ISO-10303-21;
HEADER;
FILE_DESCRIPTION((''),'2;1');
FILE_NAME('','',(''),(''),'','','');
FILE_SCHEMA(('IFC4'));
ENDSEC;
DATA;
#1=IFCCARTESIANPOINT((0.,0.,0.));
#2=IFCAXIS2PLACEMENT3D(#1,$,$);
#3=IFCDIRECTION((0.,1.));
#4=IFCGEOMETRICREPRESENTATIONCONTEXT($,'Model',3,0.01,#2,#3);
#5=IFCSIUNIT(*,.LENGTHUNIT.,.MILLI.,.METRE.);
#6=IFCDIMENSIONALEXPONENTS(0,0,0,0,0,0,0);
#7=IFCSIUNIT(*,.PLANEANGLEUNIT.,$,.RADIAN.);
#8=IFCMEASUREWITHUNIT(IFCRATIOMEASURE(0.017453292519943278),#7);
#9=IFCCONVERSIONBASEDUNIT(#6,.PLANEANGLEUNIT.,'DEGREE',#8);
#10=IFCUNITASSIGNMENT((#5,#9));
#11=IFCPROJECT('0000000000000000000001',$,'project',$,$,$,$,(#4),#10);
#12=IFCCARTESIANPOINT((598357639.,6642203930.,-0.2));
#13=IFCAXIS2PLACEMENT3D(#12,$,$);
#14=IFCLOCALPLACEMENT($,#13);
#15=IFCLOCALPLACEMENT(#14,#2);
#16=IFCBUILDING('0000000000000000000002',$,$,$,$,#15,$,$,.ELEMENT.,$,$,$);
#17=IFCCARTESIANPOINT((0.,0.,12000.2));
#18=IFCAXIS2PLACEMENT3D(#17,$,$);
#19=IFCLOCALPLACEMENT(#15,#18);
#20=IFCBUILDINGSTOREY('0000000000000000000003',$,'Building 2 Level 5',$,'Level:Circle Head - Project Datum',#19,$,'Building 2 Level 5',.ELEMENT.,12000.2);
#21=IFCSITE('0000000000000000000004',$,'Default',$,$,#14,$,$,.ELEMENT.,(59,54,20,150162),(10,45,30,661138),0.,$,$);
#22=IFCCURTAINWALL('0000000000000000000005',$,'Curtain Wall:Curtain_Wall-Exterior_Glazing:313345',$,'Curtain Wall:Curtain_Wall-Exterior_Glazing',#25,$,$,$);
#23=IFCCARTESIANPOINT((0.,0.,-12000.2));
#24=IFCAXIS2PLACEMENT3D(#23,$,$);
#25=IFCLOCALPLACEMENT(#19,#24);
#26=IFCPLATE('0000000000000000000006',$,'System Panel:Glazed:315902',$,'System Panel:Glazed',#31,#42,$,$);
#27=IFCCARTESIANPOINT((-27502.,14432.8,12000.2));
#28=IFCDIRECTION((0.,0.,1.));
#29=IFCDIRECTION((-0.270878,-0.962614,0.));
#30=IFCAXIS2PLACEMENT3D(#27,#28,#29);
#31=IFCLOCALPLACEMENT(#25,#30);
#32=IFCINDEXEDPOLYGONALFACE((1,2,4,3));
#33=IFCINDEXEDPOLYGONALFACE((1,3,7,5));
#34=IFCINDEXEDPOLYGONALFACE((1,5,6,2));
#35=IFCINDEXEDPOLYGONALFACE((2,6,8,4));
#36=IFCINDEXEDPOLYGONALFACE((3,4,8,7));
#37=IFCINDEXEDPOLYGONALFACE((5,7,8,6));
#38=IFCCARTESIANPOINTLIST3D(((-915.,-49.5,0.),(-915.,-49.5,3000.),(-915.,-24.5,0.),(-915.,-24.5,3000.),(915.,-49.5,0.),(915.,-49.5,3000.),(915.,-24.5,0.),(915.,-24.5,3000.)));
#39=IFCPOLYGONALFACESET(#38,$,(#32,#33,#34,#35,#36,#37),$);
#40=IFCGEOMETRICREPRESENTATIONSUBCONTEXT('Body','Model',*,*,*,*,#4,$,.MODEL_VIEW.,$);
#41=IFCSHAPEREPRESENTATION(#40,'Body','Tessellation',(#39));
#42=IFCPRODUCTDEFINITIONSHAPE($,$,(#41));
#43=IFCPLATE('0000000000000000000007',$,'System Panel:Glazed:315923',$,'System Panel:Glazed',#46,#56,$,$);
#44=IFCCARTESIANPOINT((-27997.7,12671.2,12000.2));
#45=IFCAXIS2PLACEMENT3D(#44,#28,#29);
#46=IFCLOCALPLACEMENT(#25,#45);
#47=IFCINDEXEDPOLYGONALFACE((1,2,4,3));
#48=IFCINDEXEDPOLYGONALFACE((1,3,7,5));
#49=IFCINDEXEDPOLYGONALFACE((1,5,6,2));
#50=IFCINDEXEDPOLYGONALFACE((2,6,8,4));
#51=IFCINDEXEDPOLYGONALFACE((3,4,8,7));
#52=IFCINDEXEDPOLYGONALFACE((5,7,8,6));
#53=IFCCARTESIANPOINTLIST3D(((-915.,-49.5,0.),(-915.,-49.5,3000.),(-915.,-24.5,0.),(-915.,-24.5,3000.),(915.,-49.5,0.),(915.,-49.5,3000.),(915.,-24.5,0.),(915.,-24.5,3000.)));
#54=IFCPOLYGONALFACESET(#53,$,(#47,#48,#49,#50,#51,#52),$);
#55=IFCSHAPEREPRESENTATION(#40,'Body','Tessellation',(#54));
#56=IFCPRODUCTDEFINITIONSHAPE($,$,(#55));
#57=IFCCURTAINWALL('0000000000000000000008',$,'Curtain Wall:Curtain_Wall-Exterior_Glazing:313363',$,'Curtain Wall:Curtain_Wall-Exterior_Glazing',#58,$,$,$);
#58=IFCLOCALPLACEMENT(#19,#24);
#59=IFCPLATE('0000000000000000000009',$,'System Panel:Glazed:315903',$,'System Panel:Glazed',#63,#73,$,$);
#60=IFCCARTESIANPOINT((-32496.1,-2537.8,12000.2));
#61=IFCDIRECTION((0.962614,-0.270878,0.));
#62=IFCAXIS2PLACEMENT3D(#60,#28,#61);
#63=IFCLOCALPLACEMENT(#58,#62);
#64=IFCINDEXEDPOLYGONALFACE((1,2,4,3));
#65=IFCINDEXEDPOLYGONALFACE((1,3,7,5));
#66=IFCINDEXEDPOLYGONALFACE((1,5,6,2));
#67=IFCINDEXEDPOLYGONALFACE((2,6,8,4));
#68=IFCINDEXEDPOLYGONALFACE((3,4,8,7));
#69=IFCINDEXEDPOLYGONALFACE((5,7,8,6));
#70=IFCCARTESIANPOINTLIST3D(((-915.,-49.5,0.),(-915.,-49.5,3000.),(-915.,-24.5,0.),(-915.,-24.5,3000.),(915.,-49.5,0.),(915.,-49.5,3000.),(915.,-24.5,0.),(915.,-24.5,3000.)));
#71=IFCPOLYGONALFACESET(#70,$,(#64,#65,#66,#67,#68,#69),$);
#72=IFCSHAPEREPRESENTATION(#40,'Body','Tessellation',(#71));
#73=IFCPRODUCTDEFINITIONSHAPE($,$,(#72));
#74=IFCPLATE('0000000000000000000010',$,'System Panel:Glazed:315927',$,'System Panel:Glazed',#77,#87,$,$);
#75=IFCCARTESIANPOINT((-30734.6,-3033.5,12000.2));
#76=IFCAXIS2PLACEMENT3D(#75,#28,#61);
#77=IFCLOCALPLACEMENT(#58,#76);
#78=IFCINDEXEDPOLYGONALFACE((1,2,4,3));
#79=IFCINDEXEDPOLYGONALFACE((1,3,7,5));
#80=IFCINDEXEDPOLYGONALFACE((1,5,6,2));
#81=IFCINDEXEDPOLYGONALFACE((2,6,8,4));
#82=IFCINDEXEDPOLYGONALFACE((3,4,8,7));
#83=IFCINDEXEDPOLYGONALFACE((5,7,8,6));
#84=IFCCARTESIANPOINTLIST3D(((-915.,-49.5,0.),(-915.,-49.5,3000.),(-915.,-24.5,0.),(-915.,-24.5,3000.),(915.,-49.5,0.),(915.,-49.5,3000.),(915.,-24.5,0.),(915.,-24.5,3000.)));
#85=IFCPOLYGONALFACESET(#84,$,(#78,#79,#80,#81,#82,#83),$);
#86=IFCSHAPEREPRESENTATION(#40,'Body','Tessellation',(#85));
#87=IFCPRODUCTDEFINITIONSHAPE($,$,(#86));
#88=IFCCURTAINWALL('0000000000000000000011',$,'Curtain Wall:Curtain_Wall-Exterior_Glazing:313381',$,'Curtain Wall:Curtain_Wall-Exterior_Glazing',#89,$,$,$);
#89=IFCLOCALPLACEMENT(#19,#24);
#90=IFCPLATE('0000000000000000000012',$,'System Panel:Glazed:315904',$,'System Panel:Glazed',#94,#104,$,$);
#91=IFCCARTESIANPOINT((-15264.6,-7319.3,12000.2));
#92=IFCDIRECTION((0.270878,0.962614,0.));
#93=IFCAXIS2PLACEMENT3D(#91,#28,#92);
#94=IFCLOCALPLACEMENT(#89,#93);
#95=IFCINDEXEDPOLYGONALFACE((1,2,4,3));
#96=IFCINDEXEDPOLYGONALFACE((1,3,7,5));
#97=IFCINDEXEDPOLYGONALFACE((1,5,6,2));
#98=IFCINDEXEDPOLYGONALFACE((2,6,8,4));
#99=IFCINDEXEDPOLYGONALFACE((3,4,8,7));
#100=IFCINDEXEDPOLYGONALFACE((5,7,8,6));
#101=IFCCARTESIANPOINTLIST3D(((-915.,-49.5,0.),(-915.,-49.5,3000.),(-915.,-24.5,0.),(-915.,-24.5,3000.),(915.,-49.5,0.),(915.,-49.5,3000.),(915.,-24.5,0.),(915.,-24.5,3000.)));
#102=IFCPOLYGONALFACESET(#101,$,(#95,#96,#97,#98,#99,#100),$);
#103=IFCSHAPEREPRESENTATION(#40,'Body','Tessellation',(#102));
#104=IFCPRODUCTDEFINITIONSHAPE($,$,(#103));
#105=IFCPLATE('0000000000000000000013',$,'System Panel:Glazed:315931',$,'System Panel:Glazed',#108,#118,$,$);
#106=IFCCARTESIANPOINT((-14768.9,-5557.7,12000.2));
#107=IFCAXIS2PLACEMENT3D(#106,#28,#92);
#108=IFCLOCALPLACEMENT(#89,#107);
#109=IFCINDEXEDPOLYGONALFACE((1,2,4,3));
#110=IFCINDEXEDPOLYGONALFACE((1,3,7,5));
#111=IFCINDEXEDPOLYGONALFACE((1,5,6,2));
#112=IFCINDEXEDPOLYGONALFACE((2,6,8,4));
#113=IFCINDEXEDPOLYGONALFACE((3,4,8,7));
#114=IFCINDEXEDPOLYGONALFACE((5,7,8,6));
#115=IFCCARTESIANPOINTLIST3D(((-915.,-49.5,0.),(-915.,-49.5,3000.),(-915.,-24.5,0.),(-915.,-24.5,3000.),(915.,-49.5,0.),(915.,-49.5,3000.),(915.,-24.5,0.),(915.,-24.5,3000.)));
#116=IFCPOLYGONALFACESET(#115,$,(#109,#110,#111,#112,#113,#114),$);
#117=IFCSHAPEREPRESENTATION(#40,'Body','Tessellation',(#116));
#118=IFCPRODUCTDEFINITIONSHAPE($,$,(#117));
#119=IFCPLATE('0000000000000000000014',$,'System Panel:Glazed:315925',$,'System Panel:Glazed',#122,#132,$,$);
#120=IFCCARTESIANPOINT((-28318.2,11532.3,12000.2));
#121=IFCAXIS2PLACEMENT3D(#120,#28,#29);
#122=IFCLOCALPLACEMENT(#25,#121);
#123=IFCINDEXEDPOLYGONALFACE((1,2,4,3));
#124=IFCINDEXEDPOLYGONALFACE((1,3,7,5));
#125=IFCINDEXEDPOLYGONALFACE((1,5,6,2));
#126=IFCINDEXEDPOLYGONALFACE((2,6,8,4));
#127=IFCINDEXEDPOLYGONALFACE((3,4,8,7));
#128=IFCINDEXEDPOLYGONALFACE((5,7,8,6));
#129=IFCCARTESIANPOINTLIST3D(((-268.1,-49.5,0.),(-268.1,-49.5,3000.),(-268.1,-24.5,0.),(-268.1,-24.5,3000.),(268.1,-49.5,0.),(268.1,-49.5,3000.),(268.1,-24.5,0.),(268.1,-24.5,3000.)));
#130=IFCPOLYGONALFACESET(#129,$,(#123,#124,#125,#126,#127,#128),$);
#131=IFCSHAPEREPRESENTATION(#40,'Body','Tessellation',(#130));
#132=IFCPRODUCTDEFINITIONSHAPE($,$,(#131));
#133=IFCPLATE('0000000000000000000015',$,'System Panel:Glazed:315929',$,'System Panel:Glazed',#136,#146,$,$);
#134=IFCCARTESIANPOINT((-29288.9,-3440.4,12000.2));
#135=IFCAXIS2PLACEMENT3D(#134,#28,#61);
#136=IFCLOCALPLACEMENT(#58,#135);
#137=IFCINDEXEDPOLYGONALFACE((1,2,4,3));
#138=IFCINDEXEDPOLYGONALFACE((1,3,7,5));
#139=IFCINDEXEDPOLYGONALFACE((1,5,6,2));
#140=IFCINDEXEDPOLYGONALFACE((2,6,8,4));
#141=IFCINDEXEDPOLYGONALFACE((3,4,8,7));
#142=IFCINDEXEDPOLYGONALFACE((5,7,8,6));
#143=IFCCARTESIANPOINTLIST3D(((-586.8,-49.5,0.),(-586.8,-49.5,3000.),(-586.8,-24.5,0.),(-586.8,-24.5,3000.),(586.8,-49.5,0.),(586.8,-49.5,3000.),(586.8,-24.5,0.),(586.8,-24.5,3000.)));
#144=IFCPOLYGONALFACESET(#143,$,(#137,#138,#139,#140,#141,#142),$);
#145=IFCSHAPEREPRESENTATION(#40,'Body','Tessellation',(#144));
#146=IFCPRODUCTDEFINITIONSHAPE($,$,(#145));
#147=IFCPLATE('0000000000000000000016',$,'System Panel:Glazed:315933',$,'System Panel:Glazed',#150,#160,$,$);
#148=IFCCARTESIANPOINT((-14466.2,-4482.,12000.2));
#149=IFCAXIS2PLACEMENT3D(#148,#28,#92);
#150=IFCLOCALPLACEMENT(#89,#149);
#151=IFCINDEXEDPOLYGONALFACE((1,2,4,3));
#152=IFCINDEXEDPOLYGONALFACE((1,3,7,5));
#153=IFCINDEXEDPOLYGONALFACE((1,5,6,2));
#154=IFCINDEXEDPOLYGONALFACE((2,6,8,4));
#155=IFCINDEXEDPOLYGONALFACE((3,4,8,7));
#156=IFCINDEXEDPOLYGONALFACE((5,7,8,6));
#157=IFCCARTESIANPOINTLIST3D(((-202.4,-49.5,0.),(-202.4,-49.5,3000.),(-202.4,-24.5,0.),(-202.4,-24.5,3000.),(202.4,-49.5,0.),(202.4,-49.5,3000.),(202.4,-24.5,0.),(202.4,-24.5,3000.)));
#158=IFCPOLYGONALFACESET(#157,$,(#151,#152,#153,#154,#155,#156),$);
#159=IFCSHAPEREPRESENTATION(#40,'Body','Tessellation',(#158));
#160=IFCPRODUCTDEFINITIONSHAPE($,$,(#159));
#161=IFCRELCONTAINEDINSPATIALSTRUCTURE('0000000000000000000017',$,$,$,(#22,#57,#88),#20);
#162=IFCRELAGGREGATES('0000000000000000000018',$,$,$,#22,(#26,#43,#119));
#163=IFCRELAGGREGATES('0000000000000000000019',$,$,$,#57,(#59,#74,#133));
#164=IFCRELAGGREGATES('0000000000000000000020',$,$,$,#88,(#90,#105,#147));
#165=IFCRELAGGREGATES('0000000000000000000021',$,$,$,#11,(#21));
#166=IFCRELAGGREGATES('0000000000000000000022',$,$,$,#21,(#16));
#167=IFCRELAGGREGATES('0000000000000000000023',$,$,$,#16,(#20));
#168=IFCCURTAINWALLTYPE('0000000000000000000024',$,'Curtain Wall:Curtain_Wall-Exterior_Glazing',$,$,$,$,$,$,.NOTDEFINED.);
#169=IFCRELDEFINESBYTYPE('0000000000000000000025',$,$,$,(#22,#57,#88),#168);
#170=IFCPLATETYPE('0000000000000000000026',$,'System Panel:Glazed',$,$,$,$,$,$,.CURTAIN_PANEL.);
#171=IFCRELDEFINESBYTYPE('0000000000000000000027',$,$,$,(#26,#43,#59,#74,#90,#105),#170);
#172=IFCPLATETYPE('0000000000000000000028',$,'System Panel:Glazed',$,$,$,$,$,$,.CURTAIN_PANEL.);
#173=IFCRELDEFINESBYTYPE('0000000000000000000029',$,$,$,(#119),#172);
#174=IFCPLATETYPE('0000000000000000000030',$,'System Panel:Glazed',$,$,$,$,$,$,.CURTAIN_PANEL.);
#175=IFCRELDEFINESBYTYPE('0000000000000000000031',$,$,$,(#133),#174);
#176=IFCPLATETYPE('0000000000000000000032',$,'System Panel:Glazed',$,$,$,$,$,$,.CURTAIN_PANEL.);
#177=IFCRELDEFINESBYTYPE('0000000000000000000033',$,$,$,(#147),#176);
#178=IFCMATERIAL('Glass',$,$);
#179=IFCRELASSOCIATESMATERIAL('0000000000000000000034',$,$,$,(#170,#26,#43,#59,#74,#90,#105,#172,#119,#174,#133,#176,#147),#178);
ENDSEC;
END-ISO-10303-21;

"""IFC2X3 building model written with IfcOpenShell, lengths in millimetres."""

from ifc_helpers import new_model, entity, si_unit, converted_unit, direction, frame, frame_2d, origin, place, context, subcontext, project, spatial, rectangle, extrude, source, transform, mapped, material, type_object, type_shapes, element, aggregate, save


model = new_model("IFC2X3")

# Units and contexts
model_context = context("Model", 3, precision=0.01, world=origin(), true_north=direction((0.0, 1.0)))
body_context = subcontext(model_context, "Body", "Model", "MODEL_VIEW")
ifc_project = project(units=[si_unit("LENGTHUNIT", "METRE", prefix="MILLI"), converted_unit("PLANEANGLEUNIT", "DEGREE", entity("IfcRatioMeasure", 0.017453292519943278), si_unit("PLANEANGLEUNIT", "RADIAN"), dimensions=[0, 0, 0, 0, 0, 0, 0])], contexts=[model_context])

# Site, building, storey
site_placement = place(None, frame((598357639.0, 6642203930.0, -0.2)))
site = spatial("IfcSite", under=ifc_project, at=site_placement, Name="Default", CompositionType="ELEMENT", RefLatitude=(59, 54, 20, 150162), RefLongitude=(10, 45, 30, 661138), RefElevation=0.0)
building_placement = place(site_placement, origin())
building = spatial("IfcBuilding", under=site, at=building_placement, CompositionType="ELEMENT")
storey_placement = place(building_placement, frame((0.0, 0.0, 12000.2)))
storey = spatial("IfcBuildingStorey", under=building, at=storey_placement, Name="Building 2 Level 5", ObjectType="Level:Circle Head - Project Datum", LongName="Building 2 Level 5", CompositionType="ELEMENT", Elevation=12000.2)

# Curtain walls, plates
curtain_wall_type = type_object("IfcCurtainWallType", Name="Curtain Wall:Curtain_Wall-Exterior_Glazing", PredefinedType="NOTDEFINED")
curtain_wall_1_placement = place(storey_placement, frame((0.0, 0.0, -12000.2)))
curtain_wall_1 = element("IfcCurtainWall", 1, at=curtain_wall_1_placement, inside=storey, type_object=curtain_wall_type, Name="Curtain Wall:Curtain_Wall-Exterior_Glazing:313345", ObjectType="Curtain Wall:Curtain_Wall-Exterior_Glazing")
ifc_material_1 = material(Name="Glass")
plate_type_1 = type_object("IfcPlateType", Name="System Panel:Glazed", PredefinedType="CURTAIN_PANEL", material=ifc_material_1)
shared_shape_1 = source(origin(), body_context, "Body", "SweptSolid", [
    extrude(rectangle(XDim=25.0, YDim=1830.0, at=frame_2d((0.0, 0.0), x_axis=(1.0, 0.0))), frame((0.0, -37.0, 0.0), z_axis=(0.0, 0.0, 1.0), x_axis=(0.0, 1.0, 0.0)), (0.0, 0.0, 1.0), 3000.0),
])
type_shapes(plate_type_1, [shared_shape_1])
plate_1_placement = place(curtain_wall_1_placement, frame((-27502.0, 14432.8, 12000.2), z_axis=(0.0, 0.0, 1.0), x_axis=(-0.270878, -0.962614, 0.0)))
plate_1 = element("IfcPlate", 2, at=plate_1_placement, type_object=plate_type_1, material=ifc_material_1, Name="System Panel:Glazed:315902", ObjectType="System Panel:Glazed", context=body_context, shape_type="MappedRepresentation", body=[
    mapped(shared_shape_1, transform((0.0, 0.0, 0.0), scale=1.0)),
])
plate_2_placement = place(curtain_wall_1_placement, frame((-27997.7, 12671.2, 12000.2), z_axis=(0.0, 0.0, 1.0), x_axis=(-0.270878, -0.962614, 0.0)))
plate_2 = element("IfcPlate", 3, at=plate_2_placement, type_object=plate_type_1, material=ifc_material_1, Name="System Panel:Glazed:315923", ObjectType="System Panel:Glazed", context=body_context, shape_type="MappedRepresentation", body=[
    mapped(shared_shape_1, transform((0.0, 0.0, 0.0), scale=1.0)),
])
curtain_wall_2_placement = place(storey_placement, frame((0.0, 0.0, -12000.2)))
curtain_wall_2 = element("IfcCurtainWall", 4, at=curtain_wall_2_placement, inside=storey, type_object=curtain_wall_type, Name="Curtain Wall:Curtain_Wall-Exterior_Glazing:313363", ObjectType="Curtain Wall:Curtain_Wall-Exterior_Glazing")
plate_3_placement = place(curtain_wall_2_placement, frame((-32496.1, -2537.8, 12000.2), z_axis=(0.0, 0.0, 1.0), x_axis=(0.962614, -0.270878, 0.0)))
plate_3 = element("IfcPlate", 5, at=plate_3_placement, type_object=plate_type_1, material=ifc_material_1, Name="System Panel:Glazed:315903", ObjectType="System Panel:Glazed", context=body_context, shape_type="MappedRepresentation", body=[
    mapped(shared_shape_1, transform((0.0, 0.0, 0.0), scale=1.0)),
])
plate_4_placement = place(curtain_wall_2_placement, frame((-30734.6, -3033.5, 12000.2), z_axis=(0.0, 0.0, 1.0), x_axis=(0.962614, -0.270878, 0.0)))
plate_4 = element("IfcPlate", 6, at=plate_4_placement, type_object=plate_type_1, material=ifc_material_1, Name="System Panel:Glazed:315927", ObjectType="System Panel:Glazed", context=body_context, shape_type="MappedRepresentation", body=[
    mapped(shared_shape_1, transform((0.0, 0.0, 0.0), scale=1.0)),
])
curtain_wall_3_placement = place(storey_placement, frame((0.0, 0.0, -12000.2)))
curtain_wall_3 = element("IfcCurtainWall", 7, at=curtain_wall_3_placement, inside=storey, type_object=curtain_wall_type, Name="Curtain Wall:Curtain_Wall-Exterior_Glazing:313381", ObjectType="Curtain Wall:Curtain_Wall-Exterior_Glazing")
plate_5_placement = place(curtain_wall_3_placement, frame((-15264.6, -7319.3, 12000.2), z_axis=(0.0, 0.0, 1.0), x_axis=(0.270878, 0.962614, 0.0)))
plate_5 = element("IfcPlate", 8, at=plate_5_placement, type_object=plate_type_1, material=ifc_material_1, Name="System Panel:Glazed:315904", ObjectType="System Panel:Glazed", context=body_context, shape_type="MappedRepresentation", body=[
    mapped(shared_shape_1, transform((0.0, 0.0, 0.0), scale=1.0)),
])
plate_6_placement = place(curtain_wall_3_placement, frame((-14768.9, -5557.7, 12000.2), z_axis=(0.0, 0.0, 1.0), x_axis=(0.270878, 0.962614, 0.0)))
plate_6 = element("IfcPlate", 9, at=plate_6_placement, type_object=plate_type_1, material=ifc_material_1, Name="System Panel:Glazed:315931", ObjectType="System Panel:Glazed", context=body_context, shape_type="MappedRepresentation", body=[
    mapped(shared_shape_1, transform((0.0, 0.0, 0.0), scale=1.0)),
])

# Plates
plate_type_2 = type_object("IfcPlateType", Name="System Panel:Glazed", PredefinedType="CURTAIN_PANEL", material=ifc_material_1)
shared_shape_2 = source(origin(), body_context, "Body", "SweptSolid", [
    extrude(rectangle(XDim=25.0, YDim=536.2, at=frame_2d((0.0, 0.0), x_axis=(1.0, 0.0))), frame((0.0, -37.0, 0.0), z_axis=(0.0, 0.0, 1.0), x_axis=(0.0, 1.0, 0.0)), (0.0, 0.0, 1.0), 3000.0),
])
type_shapes(plate_type_2, [shared_shape_2])
plate_7_placement = place(curtain_wall_1_placement, frame((-28318.2, 11532.3, 12000.2), z_axis=(0.0, 0.0, 1.0), x_axis=(-0.270878, -0.962614, 0.0)))
plate_7 = element("IfcPlate", 10, at=plate_7_placement, type_object=plate_type_2, material=ifc_material_1, Name="System Panel:Glazed:315925", ObjectType="System Panel:Glazed", context=body_context, shape_type="MappedRepresentation", body=[
    mapped(shared_shape_2, transform((0.0, 0.0, 0.0), scale=1.0)),
])
aggregate(curtain_wall_1, [plate_1, plate_2, plate_7])
plate_type_3 = type_object("IfcPlateType", Name="System Panel:Glazed", PredefinedType="CURTAIN_PANEL", material=ifc_material_1)
shared_shape_3 = source(origin(), body_context, "Body", "SweptSolid", [
    extrude(rectangle(XDim=25.0, YDim=1173.6, at=frame_2d((0.0, 0.0), x_axis=(1.0, 0.0))), frame((0.0, -37.0, 0.0), z_axis=(0.0, 0.0, 1.0), x_axis=(0.0, 1.0, 0.0)), (0.0, 0.0, 1.0), 3000.0),
])
type_shapes(plate_type_3, [shared_shape_3])
plate_8_placement = place(curtain_wall_2_placement, frame((-29288.9, -3440.4, 12000.2), z_axis=(0.0, 0.0, 1.0), x_axis=(0.962614, -0.270878, 0.0)))
plate_8 = element("IfcPlate", 11, at=plate_8_placement, type_object=plate_type_3, material=ifc_material_1, Name="System Panel:Glazed:315929", ObjectType="System Panel:Glazed", context=body_context, shape_type="MappedRepresentation", body=[
    mapped(shared_shape_3, transform((0.0, 0.0, 0.0), scale=1.0)),
])
aggregate(curtain_wall_2, [plate_3, plate_4, plate_8])
plate_type_4 = type_object("IfcPlateType", Name="System Panel:Glazed", PredefinedType="CURTAIN_PANEL", material=ifc_material_1)
shared_shape_4 = source(origin(), body_context, "Body", "SweptSolid", [
    extrude(rectangle(XDim=25.0, YDim=404.8, at=frame_2d((0.0, 0.0), x_axis=(1.0, 0.0))), frame((0.0, -37.0, 0.0), z_axis=(0.0, 0.0, 1.0), x_axis=(0.0, 1.0, 0.0)), (0.0, 0.0, 1.0), 3000.0),
])
type_shapes(plate_type_4, [shared_shape_4])
plate_9_placement = place(curtain_wall_3_placement, frame((-14466.2, -4482.0, 12000.2), z_axis=(0.0, 0.0, 1.0), x_axis=(0.270878, 0.962614, 0.0)))
plate_9 = element("IfcPlate", 12, at=plate_9_placement, type_object=plate_type_4, material=ifc_material_1, Name="System Panel:Glazed:315933", ObjectType="System Panel:Glazed", context=body_context, shape_type="MappedRepresentation", body=[
    mapped(shared_shape_4, transform((0.0, 0.0, 0.0), scale=1.0)),
])
aggregate(curtain_wall_3, [plate_5, plate_6, plate_9])

save(model, "model.ifc")
